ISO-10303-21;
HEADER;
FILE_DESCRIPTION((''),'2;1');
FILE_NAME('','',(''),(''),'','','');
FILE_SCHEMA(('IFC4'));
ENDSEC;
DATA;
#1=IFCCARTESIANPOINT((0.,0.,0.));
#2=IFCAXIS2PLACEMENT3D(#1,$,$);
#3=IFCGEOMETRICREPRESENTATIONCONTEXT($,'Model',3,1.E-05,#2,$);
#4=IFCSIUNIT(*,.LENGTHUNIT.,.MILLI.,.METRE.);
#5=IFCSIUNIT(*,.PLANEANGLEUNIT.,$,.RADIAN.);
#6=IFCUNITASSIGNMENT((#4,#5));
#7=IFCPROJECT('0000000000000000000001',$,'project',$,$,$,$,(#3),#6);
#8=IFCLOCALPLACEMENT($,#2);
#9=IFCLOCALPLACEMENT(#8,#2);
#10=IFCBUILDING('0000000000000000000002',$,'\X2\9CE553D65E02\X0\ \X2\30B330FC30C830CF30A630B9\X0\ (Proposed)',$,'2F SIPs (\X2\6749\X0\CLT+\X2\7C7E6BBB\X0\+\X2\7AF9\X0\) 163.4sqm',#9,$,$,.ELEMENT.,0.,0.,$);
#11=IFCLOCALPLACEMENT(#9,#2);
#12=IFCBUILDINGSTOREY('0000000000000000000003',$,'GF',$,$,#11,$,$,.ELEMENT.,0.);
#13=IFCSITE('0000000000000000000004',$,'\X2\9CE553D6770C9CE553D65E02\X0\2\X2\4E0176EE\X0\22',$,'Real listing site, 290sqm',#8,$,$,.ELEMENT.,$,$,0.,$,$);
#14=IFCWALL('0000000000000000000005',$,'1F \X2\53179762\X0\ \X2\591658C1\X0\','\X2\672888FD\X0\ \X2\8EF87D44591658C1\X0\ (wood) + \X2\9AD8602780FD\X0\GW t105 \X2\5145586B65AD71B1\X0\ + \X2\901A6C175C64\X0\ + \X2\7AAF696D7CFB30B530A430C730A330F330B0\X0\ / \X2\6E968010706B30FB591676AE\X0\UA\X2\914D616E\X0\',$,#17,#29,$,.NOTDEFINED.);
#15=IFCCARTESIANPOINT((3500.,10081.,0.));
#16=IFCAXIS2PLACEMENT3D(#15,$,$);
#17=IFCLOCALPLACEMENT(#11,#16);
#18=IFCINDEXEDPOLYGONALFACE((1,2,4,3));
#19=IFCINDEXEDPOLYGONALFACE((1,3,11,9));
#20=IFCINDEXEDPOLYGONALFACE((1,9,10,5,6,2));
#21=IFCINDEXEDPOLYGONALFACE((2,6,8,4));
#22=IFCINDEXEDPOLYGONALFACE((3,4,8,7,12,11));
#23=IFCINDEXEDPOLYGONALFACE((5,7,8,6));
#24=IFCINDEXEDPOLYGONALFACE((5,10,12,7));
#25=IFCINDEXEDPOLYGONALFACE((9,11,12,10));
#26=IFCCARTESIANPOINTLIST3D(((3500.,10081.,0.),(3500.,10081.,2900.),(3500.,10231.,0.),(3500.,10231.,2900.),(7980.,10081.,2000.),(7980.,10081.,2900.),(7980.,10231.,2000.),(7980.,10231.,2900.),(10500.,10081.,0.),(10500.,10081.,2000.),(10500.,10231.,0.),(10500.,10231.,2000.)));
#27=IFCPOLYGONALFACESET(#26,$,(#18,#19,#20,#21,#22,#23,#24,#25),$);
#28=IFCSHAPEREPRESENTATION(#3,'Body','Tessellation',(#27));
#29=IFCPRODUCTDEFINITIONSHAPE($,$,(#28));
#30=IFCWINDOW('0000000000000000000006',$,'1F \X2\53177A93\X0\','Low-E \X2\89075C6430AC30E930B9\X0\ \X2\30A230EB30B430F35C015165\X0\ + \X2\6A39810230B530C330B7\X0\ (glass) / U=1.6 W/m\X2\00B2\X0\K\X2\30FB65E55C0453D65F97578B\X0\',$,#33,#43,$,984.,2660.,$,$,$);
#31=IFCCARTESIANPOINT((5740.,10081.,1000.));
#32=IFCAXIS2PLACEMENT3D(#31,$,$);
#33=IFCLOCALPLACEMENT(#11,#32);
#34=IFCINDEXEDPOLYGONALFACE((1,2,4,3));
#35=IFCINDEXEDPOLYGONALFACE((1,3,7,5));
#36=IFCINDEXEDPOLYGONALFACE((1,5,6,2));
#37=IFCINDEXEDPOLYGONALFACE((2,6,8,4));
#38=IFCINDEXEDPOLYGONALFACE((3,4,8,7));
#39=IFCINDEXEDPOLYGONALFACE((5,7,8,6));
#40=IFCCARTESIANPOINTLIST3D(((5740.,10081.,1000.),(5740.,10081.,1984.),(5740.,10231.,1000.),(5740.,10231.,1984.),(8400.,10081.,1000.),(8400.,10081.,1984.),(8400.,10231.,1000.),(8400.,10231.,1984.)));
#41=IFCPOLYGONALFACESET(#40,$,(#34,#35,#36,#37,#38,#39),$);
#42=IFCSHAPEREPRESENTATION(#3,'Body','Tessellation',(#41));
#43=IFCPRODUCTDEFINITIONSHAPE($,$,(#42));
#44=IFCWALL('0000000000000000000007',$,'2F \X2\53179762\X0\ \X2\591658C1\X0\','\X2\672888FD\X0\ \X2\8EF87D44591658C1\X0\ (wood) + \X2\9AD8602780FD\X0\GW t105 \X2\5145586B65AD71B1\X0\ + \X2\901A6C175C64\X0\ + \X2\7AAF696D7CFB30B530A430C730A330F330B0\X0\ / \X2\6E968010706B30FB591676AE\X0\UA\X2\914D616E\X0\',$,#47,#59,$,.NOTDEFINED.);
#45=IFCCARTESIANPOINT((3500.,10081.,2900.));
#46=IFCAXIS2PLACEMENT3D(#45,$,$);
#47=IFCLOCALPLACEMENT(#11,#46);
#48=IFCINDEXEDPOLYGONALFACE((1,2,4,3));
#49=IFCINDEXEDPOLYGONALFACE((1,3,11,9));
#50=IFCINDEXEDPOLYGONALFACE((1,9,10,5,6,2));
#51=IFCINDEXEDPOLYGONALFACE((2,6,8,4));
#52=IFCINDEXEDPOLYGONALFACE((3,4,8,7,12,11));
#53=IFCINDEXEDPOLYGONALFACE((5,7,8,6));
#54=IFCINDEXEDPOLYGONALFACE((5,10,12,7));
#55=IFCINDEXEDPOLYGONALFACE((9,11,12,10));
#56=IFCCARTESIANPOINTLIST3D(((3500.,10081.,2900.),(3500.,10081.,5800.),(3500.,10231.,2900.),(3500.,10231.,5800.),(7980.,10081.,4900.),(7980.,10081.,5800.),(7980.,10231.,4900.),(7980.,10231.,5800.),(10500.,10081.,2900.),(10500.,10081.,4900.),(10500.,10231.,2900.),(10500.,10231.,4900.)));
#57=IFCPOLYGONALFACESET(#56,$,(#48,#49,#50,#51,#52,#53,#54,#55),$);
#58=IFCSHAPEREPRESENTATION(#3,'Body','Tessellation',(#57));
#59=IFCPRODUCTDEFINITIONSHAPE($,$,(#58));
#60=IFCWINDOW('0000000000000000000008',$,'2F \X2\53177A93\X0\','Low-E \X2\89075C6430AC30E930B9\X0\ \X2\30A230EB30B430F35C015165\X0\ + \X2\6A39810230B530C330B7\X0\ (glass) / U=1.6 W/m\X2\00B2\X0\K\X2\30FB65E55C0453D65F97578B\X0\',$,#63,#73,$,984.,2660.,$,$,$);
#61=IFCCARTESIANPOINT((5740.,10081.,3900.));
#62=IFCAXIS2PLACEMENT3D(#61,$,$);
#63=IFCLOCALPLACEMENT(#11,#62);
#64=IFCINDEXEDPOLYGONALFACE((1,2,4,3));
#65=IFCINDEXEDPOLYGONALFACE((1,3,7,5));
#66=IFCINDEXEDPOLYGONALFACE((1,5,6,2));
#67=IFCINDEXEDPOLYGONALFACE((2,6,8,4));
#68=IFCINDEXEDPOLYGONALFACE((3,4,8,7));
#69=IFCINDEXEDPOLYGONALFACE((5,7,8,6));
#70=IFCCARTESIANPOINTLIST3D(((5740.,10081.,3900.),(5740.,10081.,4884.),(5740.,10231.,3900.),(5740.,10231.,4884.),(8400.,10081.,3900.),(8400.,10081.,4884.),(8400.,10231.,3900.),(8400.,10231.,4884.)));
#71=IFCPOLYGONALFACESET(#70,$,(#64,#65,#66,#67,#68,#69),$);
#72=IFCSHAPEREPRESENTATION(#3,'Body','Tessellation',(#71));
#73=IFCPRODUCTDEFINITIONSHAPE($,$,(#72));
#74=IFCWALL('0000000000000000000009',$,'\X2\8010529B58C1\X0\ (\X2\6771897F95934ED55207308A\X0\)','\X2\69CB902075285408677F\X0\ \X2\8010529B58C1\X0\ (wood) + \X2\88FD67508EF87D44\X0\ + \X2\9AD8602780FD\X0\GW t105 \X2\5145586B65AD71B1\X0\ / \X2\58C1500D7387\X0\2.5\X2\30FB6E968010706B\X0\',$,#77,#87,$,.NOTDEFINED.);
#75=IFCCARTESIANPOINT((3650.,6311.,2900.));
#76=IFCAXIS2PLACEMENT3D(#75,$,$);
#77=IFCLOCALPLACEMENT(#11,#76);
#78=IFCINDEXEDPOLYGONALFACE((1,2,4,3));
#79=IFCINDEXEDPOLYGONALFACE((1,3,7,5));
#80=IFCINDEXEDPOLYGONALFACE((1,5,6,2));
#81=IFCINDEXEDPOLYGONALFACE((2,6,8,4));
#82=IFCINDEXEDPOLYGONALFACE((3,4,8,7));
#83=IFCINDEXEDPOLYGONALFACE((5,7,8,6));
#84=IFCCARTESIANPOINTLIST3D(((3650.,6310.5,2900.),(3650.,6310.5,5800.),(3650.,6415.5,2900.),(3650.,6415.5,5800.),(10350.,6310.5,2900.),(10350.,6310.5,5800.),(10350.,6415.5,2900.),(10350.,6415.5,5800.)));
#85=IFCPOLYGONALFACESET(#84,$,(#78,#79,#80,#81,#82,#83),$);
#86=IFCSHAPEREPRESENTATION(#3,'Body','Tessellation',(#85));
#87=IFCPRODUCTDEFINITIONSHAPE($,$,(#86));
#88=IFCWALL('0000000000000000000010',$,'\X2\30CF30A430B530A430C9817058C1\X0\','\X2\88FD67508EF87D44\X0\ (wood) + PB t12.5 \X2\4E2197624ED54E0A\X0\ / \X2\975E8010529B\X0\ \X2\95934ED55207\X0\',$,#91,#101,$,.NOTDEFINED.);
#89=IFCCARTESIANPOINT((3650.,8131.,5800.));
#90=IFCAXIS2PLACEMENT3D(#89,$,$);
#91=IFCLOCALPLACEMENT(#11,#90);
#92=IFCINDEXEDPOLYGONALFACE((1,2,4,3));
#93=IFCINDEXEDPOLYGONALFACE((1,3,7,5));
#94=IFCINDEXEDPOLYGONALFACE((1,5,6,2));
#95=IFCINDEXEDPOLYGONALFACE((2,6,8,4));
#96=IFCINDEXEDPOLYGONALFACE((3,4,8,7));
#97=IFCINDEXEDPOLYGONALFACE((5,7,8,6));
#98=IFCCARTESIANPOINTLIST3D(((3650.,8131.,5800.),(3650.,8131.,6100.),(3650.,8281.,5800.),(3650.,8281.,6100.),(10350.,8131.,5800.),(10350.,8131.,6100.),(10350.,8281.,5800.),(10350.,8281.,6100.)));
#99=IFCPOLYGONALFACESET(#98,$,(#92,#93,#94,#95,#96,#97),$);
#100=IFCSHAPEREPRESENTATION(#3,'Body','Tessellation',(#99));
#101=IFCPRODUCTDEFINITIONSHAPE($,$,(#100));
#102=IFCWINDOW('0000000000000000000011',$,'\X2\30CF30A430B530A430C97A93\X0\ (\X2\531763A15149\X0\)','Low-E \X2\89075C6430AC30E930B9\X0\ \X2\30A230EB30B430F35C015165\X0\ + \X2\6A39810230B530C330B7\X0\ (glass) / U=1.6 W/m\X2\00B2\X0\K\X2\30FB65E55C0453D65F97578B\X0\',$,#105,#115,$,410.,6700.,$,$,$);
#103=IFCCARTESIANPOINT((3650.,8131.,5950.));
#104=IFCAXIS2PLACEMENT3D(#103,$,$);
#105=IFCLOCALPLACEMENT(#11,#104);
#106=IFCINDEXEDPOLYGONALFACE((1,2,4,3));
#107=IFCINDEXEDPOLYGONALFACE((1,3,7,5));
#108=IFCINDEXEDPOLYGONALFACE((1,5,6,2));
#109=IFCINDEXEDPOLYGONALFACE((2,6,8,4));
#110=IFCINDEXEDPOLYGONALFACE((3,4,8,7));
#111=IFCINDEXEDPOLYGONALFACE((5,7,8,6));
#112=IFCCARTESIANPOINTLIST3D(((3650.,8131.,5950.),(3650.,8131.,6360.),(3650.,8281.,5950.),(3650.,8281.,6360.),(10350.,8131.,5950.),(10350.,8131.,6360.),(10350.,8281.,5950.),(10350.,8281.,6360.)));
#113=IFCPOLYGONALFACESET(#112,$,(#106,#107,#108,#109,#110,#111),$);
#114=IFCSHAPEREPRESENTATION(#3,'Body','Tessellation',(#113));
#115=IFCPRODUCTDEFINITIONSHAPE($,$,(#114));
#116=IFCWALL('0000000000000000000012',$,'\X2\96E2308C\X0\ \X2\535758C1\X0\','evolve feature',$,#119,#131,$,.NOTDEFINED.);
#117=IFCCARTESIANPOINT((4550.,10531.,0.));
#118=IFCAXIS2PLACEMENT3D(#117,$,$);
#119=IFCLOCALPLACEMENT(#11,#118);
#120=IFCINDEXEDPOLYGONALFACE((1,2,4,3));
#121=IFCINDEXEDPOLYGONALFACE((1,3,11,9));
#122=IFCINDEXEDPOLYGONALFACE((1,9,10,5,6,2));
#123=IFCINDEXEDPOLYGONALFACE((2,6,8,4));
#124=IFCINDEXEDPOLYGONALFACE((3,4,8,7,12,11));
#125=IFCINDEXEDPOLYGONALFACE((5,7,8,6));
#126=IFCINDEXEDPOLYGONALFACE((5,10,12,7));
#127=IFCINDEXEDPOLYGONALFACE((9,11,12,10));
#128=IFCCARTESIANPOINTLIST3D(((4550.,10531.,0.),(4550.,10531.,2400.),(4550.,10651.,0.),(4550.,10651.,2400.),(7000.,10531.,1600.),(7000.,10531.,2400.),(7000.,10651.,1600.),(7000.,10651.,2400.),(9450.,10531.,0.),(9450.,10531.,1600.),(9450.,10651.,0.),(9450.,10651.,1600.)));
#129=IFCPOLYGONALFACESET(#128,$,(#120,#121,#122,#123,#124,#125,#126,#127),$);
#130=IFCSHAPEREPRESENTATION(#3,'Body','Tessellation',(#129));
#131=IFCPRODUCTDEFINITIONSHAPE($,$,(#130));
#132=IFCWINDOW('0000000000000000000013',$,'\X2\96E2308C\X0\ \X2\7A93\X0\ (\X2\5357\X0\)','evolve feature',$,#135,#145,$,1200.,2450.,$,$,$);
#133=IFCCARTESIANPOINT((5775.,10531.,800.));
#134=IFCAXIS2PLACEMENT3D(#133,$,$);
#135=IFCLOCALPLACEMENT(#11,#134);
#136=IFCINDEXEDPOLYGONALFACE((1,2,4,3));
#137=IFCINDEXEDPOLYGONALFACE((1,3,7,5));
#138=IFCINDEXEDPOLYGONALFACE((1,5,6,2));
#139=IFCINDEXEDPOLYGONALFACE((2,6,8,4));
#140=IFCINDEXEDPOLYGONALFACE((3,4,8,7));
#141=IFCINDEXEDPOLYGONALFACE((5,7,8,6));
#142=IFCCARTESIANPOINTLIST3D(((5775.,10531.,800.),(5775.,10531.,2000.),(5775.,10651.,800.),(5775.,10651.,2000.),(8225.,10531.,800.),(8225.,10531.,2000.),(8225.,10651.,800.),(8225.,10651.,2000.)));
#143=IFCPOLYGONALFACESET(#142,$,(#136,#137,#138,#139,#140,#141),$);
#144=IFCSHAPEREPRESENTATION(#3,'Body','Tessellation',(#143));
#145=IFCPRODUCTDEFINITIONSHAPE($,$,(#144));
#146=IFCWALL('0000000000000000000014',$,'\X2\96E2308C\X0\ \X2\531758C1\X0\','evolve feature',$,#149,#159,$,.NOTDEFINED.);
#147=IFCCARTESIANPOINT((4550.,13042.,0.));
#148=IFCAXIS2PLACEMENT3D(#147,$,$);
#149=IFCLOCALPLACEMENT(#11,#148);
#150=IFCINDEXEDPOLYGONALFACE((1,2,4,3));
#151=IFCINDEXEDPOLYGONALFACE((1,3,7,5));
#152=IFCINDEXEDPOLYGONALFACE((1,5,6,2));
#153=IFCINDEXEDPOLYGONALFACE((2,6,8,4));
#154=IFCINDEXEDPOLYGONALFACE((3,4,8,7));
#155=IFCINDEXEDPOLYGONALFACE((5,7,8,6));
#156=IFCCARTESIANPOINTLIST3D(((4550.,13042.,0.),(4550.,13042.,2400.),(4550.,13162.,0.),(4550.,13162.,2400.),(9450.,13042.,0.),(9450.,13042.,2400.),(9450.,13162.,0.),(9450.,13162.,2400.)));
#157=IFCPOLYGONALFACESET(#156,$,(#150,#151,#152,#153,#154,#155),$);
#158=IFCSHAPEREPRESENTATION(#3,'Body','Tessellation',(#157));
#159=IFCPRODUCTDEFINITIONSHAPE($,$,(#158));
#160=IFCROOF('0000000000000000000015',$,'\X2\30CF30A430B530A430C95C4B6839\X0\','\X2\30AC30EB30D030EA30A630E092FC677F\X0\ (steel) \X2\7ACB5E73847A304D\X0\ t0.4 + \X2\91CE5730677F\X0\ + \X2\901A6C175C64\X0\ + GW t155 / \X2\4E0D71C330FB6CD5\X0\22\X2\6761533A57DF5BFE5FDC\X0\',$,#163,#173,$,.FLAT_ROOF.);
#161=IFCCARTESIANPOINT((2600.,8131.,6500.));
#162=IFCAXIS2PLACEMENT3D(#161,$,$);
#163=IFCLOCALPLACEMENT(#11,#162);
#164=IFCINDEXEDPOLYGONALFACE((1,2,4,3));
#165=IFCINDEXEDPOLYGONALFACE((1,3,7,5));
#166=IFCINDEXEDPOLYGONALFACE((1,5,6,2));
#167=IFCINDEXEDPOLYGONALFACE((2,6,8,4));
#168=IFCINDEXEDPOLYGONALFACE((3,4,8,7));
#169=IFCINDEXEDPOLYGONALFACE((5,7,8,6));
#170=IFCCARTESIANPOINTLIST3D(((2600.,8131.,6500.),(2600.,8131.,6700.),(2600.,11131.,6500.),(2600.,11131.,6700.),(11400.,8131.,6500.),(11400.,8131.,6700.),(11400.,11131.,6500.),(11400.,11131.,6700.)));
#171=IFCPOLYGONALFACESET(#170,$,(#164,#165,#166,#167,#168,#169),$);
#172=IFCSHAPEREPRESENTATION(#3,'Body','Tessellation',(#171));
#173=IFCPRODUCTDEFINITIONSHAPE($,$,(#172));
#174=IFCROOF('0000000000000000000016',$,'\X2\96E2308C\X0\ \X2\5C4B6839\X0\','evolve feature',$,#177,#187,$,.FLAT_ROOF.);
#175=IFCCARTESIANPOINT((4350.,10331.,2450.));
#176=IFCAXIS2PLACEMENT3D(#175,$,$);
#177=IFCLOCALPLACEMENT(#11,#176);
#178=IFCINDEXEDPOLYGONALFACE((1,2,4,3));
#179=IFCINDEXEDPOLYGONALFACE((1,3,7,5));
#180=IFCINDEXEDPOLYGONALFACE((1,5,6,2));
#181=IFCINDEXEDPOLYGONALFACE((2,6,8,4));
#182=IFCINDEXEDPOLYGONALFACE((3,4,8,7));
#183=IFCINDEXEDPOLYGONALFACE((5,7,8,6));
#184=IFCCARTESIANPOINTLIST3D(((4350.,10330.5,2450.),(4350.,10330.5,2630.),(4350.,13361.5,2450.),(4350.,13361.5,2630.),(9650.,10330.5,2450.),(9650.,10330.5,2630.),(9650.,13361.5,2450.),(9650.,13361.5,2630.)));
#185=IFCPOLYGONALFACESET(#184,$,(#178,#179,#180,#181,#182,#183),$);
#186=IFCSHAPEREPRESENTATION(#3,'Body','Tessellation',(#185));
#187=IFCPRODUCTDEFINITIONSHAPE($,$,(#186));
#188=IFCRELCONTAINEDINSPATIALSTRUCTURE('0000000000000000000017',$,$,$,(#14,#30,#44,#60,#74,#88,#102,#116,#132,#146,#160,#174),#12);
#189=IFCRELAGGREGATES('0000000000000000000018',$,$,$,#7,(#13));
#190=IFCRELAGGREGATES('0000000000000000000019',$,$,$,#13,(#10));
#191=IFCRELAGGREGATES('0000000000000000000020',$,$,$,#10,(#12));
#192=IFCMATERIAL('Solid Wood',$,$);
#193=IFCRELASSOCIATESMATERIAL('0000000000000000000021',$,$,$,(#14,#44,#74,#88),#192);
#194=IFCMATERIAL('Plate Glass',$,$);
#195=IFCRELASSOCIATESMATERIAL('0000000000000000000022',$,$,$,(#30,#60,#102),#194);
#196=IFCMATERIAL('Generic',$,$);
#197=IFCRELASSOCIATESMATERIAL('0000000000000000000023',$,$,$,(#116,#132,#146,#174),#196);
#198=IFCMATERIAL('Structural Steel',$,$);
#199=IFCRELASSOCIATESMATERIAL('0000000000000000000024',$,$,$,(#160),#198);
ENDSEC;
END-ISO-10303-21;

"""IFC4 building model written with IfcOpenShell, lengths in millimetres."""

from ifc_helpers import new_model, si_unit, frame, frame_2d, origin, place, context, project, spatial, rectangle, extrude, material, element, fill, save


model = new_model("IFC4")

# Units and contexts
model_context = context("Model", 3, precision=1e-05, world=origin())
ifc_project = project(units=[si_unit("LENGTHUNIT", "METRE", prefix="MILLI"), si_unit("PLANEANGLEUNIT", "RADIAN")], contexts=[model_context])

# Site, building, storey
site_placement = place(None, origin())
site = spatial("IfcSite", under=ifc_project, at=site_placement, Name="鳥取県鳥取市2丁目22", ObjectType="Real listing site, 290sqm", CompositionType="ELEMENT", RefElevation=0.0)
building_placement = place(site_placement, origin())
building = spatial("IfcBuilding", under=site, at=building_placement, Name="鳥取市 コートハウス (Proposed)", ObjectType="2F SIPs (杉CLT+籾殻+竹) 163.4sqm", CompositionType="ELEMENT", ElevationOfRefHeight=0.0, ElevationOfTerrain=0.0)
storey_placement = place(building_placement, origin())
storey = spatial("IfcBuildingStorey", under=building, at=storey_placement, Name="GF", CompositionType="ELEMENT", Elevation=0.0)

# Shared definitions
ifc_material_1 = material(Name="Generic")

# Wall, opening, window
ifc_material_2 = material(Name="Solid Wood")
wall_1_placement = place(storey_placement, frame((3500.0, 10081.0, 0.0)))
wall_1 = element("IfcWall", 1, at=wall_1_placement, inside=storey, material=ifc_material_2, Name="1F 北面 外壁", Description="木製 軸組外壁 (wood) + 高性能GW t105 充填断熱 + 通気層 + 窯業系サイディング / 準耐火・外皮UA配慮", PredefinedType="NOTDEFINED", context=model_context, shape_type="SweptSolid", body=[
    extrude(rectangle(XDim=7000.0, YDim=150.0, at=frame_2d((3500.0, 75.0))), frame((3500.0, 10081.0, 0.0)), (0.0, 0.0, 1.0), 2900.0),
])
opening_1_placement = place(storey_placement, frame((5740.0, 10081.0, 1000.0)))
opening_1 = element("IfcOpeningElement", 2, at=opening_1_placement, cuts=wall_1, PredefinedType="NOTDEFINED", context=model_context, shape_type="SweptSolid", body=[
    extrude(rectangle(XDim=2660.0, YDim=150.0, at=frame_2d((1330.0, 75.0))), frame((5740.0, 10081.0, 1000.0)), (0.0, 0.0, 1.0), 984.0),
])
ifc_material_3 = material(Name="Plate Glass")
window_1_placement = place(storey_placement, frame((5740.0, 10081.0, 1000.0)))
window_1 = element("IfcWindow", 3, at=window_1_placement, inside=storey, material=ifc_material_3, Name="1F 北窓", Description="Low-E 複層ガラス アルゴン封入 + 樹脂サッシ (glass) / U=1.6 W/m²K・日射取得型", OverallHeight=984.0, OverallWidth=2660.0, context=model_context, shape_type="SweptSolid", body=[
    extrude(rectangle(XDim=2660.0, YDim=150.0, at=frame_2d((1330.0, 75.0))), frame((5740.0, 10081.0, 1000.0)), (0.0, 0.0, 1.0), 984.0),
])
fill(opening_1, window_1)

# Wall, opening, window
wall_2_placement = place(storey_placement, frame((3500.0, 10081.0, 2900.0)))
wall_2 = element("IfcWall", 4, at=wall_2_placement, inside=storey, material=ifc_material_2, Name="2F 北面 外壁", Description="木製 軸組外壁 (wood) + 高性能GW t105 充填断熱 + 通気層 + 窯業系サイディング / 準耐火・外皮UA配慮", PredefinedType="NOTDEFINED", context=model_context, shape_type="SweptSolid", body=[
    extrude(rectangle(XDim=7000.0, YDim=150.0, at=frame_2d((3500.0, 75.0))), frame((3500.0, 10081.0, 2900.0)), (0.0, 0.0, 1.0), 2900.0),
])
opening_2_placement = place(storey_placement, frame((5740.0, 10081.0, 3900.0)))
opening_2 = element("IfcOpeningElement", 5, at=opening_2_placement, cuts=wall_2, PredefinedType="NOTDEFINED", context=model_context, shape_type="SweptSolid", body=[
    extrude(rectangle(XDim=2660.0, YDim=150.0, at=frame_2d((1330.0, 75.0))), frame((5740.0, 10081.0, 3900.0)), (0.0, 0.0, 1.0), 984.0),
])
window_2_placement = place(storey_placement, frame((5740.0, 10081.0, 3900.0)))
window_2 = element("IfcWindow", 6, at=window_2_placement, inside=storey, material=ifc_material_3, Name="2F 北窓", Description="Low-E 複層ガラス アルゴン封入 + 樹脂サッシ (glass) / U=1.6 W/m²K・日射取得型", OverallHeight=984.0, OverallWidth=2660.0, context=model_context, shape_type="SweptSolid", body=[
    extrude(rectangle(XDim=2660.0, YDim=150.0, at=frame_2d((1330.0, 75.0))), frame((5740.0, 10081.0, 3900.0)), (0.0, 0.0, 1.0), 984.0),
])
fill(opening_2, window_2)

# Wall
wall_3_placement = place(storey_placement, frame((3650.0, 6311.0, 2900.0)))
element("IfcWall", 7, at=wall_3_placement, inside=storey, material=ifc_material_2, Name="耐力壁 (東西間仕切り)", Description="構造用合板 耐力壁 (wood) + 製材軸組 + 高性能GW t105 充填断熱 / 壁倍率2.5・準耐火", PredefinedType="NOTDEFINED", context=model_context, shape_type="SweptSolid", body=[
    extrude(rectangle(XDim=6700.0, YDim=105.0, at=frame_2d((3350.0, 52.0))), frame((3650.0, 6311.0, 2900.0)), (0.0, 0.0, 1.0), 2900.0),
])

# Walls, openings, windows
wall_4_placement = place(storey_placement, frame((3650.0, 8131.0, 5800.0)))
wall_4 = element("IfcWall", 8, at=wall_4_placement, inside=storey, material=ifc_material_2, Name="ハイサイド腰壁", Description="製材軸組 (wood) + PB t12.5 両面仕上 / 非耐力 間仕切", PredefinedType="NOTDEFINED", context=model_context, shape_type="SweptSolid", body=[
    extrude(rectangle(XDim=6700.0, YDim=150.0, at=frame_2d((3350.0, 75.0))), frame((3650.0, 8131.0, 5800.0)), (0.0, 0.0, 1.0), 700.0),
])
opening_3_placement = place(storey_placement, frame((3650.0, 8131.0, 5950.0)))
opening_3 = element("IfcOpeningElement", 9, at=opening_3_placement, cuts=wall_4, PredefinedType="NOTDEFINED", context=model_context, shape_type="SweptSolid", body=[
    extrude(rectangle(XDim=6700.0, YDim=150.0, at=frame_2d((3350.0, 75.0))), frame((3650.0, 8131.0, 5950.0)), (0.0, 0.0, 1.0), 410.0),
])
window_3_placement = place(storey_placement, frame((3650.0, 8131.0, 5950.0)))
window_3 = element("IfcWindow", 10, at=window_3_placement, inside=storey, material=ifc_material_3, Name="ハイサイド窓 (北採光)", Description="Low-E 複層ガラス アルゴン封入 + 樹脂サッシ (glass) / U=1.6 W/m²K・日射取得型", OverallHeight=410.0, OverallWidth=6700.0, context=model_context, shape_type="SweptSolid", body=[
    extrude(rectangle(XDim=6700.0, YDim=150.0, at=frame_2d((3350.0, 75.0))), frame((3650.0, 8131.0, 5950.0)), (0.0, 0.0, 1.0), 410.0),
])
fill(opening_3, window_3)
wall_5_placement = place(storey_placement, frame((4550.0, 10531.0, 0.0)))
wall_5 = element("IfcWall", 11, at=wall_5_placement, inside=storey, material=ifc_material_1, Name="離れ 南壁", Description="evolve feature", PredefinedType="NOTDEFINED", context=model_context, shape_type="SweptSolid", body=[
    extrude(rectangle(XDim=4900.0, YDim=120.0, at=frame_2d((2450.0, 60.0))), frame((4550.0, 10531.0, 0.0)), (0.0, 0.0, 1.0), 2400.0),
])
opening_4_placement = place(storey_placement, frame((5775.0, 10531.0, 800.0)))
opening_4 = element("IfcOpeningElement", 12, at=opening_4_placement, cuts=wall_5, PredefinedType="NOTDEFINED", context=model_context, shape_type="SweptSolid", body=[
    extrude(rectangle(XDim=2450.0, YDim=120.0, at=frame_2d((1225.0, 60.0))), frame((5775.0, 10531.0, 800.0)), (0.0, 0.0, 1.0), 1200.0),
])
window_4_placement = place(storey_placement, frame((5775.0, 10531.0, 800.0)))
window_4 = element("IfcWindow", 13, at=window_4_placement, inside=storey, material=ifc_material_1, Name="離れ 窓 (南)", Description="evolve feature", OverallHeight=1200.0, OverallWidth=2450.0, context=model_context, shape_type="SweptSolid", body=[
    extrude(rectangle(XDim=2450.0, YDim=120.0, at=frame_2d((1225.0, 60.0))), frame((5775.0, 10531.0, 800.0)), (0.0, 0.0, 1.0), 1200.0),
])
fill(opening_4, window_4)

# Wall
wall_6_placement = place(storey_placement, frame((4550.0, 13042.0, 0.0)))
element("IfcWall", 14, at=wall_6_placement, inside=storey, material=ifc_material_1, Name="離れ 北壁", Description="evolve feature", PredefinedType="NOTDEFINED", context=model_context, shape_type="SweptSolid", body=[
    extrude(rectangle(XDim=4900.0, YDim=120.0, at=frame_2d((2450.0, 60.0))), frame((4550.0, 13042.0, 0.0)), (0.0, 0.0, 1.0), 2400.0),
])

# Roofs
ifc_material_4 = material(Name="Structural Steel")
roof_1_placement = place(storey_placement, frame((2600.0, 8131.0, 6500.0)))
element("IfcRoof", 15, at=roof_1_placement, inside=storey, material=ifc_material_4, Name="ハイサイド屋根", Description="ガルバリウム鋼板 (steel) 立平葺き t0.4 + 野地板 + 通気層 + GW t155 / 不燃・法22条区域対応", PredefinedType="FLAT_ROOF", context=model_context, shape_type="SweptSolid", body=[
    extrude(rectangle(XDim=8800.0, YDim=3000.0, at=frame_2d((4400.0, 1500.0))), frame((2600.0, 8131.0, 6500.0)), (0.0, 0.0, 1.0), 200.0),
])
roof_2_placement = place(storey_placement, frame((4350.0, 10331.0, 2450.0)))
element("IfcRoof", 16, at=roof_2_placement, inside=storey, material=ifc_material_1, Name="離れ 屋根", Description="evolve feature", PredefinedType="FLAT_ROOF", context=model_context, shape_type="SweptSolid", body=[
    extrude(rectangle(XDim=5300.0, YDim=3031.0, at=frame_2d((2650.0, 1515.0))), frame((4350.0, 10331.0, 2450.0)), (0.0, 0.0, 1.0), 180.0),
])

save(model, "model.ifc")
